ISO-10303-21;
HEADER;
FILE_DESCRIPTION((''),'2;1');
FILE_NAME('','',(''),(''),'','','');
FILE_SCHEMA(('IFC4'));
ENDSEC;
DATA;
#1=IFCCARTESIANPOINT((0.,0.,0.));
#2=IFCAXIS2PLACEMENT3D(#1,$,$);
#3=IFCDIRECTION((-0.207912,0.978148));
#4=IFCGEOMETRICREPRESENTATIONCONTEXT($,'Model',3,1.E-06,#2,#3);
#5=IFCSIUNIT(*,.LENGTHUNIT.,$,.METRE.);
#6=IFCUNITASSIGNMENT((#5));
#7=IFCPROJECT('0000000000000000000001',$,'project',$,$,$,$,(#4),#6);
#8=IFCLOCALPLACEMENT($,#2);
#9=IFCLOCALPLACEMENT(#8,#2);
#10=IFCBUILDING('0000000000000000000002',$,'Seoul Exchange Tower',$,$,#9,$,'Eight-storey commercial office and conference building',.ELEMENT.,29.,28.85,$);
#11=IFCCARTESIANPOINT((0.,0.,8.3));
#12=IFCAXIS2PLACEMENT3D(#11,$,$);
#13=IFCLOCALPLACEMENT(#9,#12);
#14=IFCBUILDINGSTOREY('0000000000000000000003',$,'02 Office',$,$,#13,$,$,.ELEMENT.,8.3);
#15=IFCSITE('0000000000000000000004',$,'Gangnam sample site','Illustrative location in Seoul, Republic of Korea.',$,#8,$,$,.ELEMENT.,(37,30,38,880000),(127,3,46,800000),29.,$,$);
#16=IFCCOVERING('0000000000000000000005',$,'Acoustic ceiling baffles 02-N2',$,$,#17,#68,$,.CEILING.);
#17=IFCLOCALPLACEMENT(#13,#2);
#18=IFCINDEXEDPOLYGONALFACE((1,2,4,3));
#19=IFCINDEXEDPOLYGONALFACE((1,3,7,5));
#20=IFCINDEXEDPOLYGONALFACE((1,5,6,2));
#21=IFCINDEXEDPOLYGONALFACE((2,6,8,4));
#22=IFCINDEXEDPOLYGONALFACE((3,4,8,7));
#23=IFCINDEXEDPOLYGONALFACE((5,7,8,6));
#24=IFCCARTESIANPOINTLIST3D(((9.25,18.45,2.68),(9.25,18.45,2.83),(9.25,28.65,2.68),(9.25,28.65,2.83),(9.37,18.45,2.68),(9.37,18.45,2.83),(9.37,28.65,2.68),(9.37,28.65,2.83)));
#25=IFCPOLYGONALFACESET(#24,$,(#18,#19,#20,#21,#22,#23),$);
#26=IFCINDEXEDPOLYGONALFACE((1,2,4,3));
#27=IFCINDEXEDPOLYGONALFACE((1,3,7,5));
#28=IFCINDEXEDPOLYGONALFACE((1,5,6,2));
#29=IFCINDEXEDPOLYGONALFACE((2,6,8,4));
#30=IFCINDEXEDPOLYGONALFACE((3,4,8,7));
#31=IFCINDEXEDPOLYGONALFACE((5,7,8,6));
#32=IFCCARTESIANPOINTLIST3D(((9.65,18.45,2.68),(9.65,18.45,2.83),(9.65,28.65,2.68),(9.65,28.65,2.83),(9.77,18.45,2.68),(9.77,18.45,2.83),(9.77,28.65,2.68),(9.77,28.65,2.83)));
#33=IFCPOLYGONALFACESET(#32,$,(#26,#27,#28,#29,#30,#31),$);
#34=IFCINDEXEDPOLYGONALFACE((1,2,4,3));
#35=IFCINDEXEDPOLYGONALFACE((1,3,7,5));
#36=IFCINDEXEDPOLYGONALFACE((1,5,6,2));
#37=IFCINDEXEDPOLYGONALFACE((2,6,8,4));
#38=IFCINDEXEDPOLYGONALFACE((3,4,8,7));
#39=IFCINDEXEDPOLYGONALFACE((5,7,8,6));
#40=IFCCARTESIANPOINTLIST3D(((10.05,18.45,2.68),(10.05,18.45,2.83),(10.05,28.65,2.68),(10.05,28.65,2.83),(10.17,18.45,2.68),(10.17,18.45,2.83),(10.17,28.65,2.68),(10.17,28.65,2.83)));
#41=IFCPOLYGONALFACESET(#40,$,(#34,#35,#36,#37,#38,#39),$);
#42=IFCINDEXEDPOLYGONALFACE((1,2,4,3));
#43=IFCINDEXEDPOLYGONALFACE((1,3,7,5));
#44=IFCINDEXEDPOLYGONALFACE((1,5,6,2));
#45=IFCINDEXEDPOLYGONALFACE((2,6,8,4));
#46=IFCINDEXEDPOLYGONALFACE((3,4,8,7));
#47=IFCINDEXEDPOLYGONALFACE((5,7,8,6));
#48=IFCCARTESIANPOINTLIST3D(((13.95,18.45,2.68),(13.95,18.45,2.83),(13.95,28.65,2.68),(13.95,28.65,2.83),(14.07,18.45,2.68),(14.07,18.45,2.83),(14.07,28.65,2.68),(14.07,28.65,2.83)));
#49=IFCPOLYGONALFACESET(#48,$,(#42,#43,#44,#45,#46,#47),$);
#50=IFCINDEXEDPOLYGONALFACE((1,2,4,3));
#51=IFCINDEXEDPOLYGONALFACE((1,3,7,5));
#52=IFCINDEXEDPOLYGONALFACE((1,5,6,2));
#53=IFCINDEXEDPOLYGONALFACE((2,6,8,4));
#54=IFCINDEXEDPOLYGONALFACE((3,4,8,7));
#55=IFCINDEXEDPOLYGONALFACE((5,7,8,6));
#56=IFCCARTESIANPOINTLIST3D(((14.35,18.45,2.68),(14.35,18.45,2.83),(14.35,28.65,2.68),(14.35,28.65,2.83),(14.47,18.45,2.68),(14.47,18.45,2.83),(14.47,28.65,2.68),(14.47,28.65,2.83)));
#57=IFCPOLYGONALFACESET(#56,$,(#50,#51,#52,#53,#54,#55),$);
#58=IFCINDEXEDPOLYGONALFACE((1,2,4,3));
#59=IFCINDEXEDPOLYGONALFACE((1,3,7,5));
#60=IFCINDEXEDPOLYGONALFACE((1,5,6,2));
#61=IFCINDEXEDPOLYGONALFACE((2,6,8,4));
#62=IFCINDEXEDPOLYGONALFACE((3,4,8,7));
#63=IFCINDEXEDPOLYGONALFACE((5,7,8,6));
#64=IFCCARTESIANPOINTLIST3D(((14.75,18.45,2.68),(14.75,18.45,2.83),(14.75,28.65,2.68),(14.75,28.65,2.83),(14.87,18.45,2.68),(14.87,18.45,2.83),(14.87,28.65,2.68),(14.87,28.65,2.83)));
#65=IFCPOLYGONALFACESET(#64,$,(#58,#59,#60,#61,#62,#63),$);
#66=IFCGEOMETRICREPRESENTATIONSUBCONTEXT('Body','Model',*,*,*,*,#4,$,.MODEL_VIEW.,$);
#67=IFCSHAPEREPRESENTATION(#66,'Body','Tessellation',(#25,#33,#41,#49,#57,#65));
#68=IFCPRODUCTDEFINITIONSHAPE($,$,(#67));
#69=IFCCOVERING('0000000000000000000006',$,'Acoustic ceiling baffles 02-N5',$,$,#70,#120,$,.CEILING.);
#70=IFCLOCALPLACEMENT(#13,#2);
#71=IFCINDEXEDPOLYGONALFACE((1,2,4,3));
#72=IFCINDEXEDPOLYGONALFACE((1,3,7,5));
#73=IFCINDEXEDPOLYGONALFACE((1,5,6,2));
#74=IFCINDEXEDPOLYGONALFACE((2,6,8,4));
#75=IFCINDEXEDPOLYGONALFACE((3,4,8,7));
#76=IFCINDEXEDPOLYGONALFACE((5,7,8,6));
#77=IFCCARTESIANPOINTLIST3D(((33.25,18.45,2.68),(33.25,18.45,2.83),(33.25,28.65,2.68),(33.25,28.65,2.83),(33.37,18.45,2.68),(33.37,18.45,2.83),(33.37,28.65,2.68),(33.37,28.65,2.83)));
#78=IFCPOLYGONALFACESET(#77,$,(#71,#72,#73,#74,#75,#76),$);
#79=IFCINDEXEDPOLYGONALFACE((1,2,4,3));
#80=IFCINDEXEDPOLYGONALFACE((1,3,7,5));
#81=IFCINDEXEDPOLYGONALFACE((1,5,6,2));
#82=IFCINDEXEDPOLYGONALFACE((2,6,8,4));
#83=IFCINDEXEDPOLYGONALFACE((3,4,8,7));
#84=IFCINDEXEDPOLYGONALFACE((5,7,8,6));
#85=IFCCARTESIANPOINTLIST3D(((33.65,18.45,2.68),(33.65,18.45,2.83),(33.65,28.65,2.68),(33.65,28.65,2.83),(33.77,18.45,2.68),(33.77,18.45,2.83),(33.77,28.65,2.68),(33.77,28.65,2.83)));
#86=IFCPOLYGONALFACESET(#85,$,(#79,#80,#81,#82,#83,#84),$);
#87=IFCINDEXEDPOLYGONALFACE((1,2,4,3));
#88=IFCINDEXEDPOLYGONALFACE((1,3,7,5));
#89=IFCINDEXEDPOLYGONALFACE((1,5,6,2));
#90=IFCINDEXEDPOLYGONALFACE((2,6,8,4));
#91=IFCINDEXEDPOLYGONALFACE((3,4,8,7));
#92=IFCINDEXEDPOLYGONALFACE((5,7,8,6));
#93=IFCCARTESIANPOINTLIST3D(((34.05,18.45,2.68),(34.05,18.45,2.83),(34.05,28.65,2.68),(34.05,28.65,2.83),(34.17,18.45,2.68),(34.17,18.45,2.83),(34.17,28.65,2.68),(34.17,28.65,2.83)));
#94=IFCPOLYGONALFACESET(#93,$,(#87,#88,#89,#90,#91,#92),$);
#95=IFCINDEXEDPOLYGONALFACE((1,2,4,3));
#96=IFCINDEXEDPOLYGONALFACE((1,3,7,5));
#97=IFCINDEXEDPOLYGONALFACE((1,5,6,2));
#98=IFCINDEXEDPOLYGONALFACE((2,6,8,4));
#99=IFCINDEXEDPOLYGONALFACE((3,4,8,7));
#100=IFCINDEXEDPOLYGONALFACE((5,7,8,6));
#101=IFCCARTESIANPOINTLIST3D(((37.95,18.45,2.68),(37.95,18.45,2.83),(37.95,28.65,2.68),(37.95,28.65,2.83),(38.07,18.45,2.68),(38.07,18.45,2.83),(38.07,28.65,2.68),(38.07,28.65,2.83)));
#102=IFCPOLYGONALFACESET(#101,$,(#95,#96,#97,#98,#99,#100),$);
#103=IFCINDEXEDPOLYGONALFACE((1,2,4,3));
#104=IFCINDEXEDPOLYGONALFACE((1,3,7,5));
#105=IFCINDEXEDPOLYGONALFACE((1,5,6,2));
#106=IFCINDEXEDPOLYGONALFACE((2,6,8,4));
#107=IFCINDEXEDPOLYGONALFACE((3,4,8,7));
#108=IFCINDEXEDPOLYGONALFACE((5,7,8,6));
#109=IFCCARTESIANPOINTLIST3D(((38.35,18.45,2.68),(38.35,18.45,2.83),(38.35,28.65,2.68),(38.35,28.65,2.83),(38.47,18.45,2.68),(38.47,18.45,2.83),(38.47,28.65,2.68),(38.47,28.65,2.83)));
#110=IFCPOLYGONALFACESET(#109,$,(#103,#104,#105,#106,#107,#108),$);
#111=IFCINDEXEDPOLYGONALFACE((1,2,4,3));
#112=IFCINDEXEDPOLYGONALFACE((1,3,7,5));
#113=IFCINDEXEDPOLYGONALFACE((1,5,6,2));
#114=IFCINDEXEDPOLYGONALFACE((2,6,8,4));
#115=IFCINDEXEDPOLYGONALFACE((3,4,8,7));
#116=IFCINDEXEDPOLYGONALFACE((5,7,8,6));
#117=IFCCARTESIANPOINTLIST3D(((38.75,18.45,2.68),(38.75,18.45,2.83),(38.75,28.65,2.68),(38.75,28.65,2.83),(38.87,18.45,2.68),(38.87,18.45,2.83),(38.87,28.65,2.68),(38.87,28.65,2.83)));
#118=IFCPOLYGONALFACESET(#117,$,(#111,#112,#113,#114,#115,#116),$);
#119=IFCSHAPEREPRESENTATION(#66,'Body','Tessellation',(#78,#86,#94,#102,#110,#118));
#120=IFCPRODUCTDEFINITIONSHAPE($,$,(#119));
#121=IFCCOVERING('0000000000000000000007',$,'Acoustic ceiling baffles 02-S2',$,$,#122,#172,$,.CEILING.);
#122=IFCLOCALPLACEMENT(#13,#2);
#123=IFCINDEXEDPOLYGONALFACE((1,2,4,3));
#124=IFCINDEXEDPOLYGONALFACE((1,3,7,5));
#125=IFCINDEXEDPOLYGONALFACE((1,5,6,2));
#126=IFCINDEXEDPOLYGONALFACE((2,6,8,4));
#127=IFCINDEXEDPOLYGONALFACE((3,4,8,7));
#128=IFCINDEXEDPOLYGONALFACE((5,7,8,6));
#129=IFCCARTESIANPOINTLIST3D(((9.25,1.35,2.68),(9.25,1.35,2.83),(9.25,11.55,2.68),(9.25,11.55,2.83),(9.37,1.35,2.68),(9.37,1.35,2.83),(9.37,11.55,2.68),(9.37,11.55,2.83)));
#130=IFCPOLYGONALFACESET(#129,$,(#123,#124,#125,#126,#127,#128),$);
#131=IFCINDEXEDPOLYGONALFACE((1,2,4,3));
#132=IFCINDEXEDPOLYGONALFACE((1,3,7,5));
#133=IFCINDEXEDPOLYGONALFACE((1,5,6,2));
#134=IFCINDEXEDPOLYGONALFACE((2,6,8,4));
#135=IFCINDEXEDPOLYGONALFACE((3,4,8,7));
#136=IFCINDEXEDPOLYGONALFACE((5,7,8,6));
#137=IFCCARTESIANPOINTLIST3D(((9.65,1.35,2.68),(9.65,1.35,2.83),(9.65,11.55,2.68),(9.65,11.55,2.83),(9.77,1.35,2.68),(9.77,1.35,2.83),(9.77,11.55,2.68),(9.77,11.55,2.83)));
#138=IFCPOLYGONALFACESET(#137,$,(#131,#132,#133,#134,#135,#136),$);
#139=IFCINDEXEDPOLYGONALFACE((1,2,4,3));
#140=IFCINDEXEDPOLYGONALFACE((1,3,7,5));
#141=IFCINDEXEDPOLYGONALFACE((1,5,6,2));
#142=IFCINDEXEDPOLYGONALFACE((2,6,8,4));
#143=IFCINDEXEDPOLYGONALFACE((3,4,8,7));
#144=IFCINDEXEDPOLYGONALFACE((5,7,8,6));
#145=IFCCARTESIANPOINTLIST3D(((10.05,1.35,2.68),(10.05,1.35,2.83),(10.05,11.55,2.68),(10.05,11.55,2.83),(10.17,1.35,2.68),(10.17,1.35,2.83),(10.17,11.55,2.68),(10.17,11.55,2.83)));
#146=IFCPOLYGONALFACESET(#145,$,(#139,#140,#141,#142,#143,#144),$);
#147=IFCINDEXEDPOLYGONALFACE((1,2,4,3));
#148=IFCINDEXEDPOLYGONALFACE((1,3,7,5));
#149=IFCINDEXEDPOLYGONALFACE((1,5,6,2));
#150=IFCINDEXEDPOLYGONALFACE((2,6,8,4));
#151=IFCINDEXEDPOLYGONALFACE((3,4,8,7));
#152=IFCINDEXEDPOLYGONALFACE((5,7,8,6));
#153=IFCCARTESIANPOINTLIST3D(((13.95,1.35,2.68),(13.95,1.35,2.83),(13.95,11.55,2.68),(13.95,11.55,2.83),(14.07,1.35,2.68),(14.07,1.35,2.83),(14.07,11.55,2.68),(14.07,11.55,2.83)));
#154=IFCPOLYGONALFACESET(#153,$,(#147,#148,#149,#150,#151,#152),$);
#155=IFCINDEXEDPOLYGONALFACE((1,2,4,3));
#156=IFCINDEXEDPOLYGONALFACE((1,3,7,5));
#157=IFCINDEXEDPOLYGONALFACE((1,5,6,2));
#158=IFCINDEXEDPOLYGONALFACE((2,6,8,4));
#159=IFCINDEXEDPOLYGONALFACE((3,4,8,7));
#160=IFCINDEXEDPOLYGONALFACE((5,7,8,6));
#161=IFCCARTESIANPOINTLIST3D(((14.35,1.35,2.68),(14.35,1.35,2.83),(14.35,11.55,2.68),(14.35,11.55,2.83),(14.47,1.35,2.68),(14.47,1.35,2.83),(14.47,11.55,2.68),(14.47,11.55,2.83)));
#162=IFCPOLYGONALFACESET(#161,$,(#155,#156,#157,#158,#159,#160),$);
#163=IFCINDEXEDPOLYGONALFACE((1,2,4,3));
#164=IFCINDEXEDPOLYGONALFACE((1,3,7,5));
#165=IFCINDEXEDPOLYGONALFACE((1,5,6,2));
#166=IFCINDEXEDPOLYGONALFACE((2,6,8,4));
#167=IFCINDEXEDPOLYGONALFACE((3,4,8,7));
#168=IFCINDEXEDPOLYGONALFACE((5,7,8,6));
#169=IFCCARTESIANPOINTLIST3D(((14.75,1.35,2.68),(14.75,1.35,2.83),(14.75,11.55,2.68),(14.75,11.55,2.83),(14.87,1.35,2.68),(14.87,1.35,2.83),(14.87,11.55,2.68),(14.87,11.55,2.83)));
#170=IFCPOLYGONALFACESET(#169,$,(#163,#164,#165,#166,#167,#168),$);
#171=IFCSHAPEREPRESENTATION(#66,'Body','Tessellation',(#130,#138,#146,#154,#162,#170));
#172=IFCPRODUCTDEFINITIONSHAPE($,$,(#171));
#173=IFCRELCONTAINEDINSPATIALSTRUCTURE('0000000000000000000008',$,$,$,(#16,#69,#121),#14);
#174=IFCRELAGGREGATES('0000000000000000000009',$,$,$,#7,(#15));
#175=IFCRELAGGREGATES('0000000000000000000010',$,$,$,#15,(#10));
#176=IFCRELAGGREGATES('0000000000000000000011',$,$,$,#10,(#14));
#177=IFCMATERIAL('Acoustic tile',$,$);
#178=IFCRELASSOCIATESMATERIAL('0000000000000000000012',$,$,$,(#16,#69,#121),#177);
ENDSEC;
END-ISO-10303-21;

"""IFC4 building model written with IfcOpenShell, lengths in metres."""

from ifc_helpers import new_model, si_unit, direction, frame, frame_2d, origin, place, context, subcontext, project, spatial, rectangle, extrude, material, element, save


model = new_model("IFC4")

# Units and contexts
model_context = context("Model", 3, precision=1e-06, world=origin(), true_north=direction((-0.207912, 0.978148)))
body_context = subcontext(model_context, "Body", "Model", "MODEL_VIEW")
ifc_project = project(units=[si_unit("LENGTHUNIT", "METRE")], contexts=[model_context])

# Site, building, storey
site_placement = place(None, origin())
site = spatial("IfcSite", under=ifc_project, at=site_placement, Name="Gangnam sample site", Description="Illustrative location in Seoul, Republic of Korea.", CompositionType="ELEMENT", RefLatitude=(37, 30, 38, 880000), RefLongitude=(127, 3, 46, 800000), RefElevation=29.0)
building_placement = place(site_placement, origin())
building = spatial("IfcBuilding", under=site, at=building_placement, Name="Seoul Exchange Tower", LongName="Eight-storey commercial office and conference building", CompositionType="ELEMENT", ElevationOfRefHeight=29.0, ElevationOfTerrain=28.85)
storey_placement = place(building_placement, frame((0.0, 0.0, 8.3)))
storey = spatial("IfcBuildingStorey", under=building, at=storey_placement, Name="02 Office", CompositionType="ELEMENT", Elevation=8.3)

# Shared definitions
placement_1 = place(storey_placement, origin())

# Coverings
ifc_material_1 = material(Name="Acoustic tile")
element("IfcCovering", 1, at=placement_1, inside=storey, material=ifc_material_1, Name="Acoustic ceiling baffles 02-N2", PredefinedType="CEILING", context=body_context, shape_type="SweptSolid", body=[
    extrude(rectangle(XDim=0.12, YDim=10.2, at=frame_2d((0.06, 5.1))), frame((9.25, 18.45, 2.68)), (0.0, 0.0, 1.0), 0.15),
    extrude(rectangle(XDim=0.12, YDim=10.2, at=frame_2d((0.06, 5.1))), frame((9.65, 18.45, 2.68)), (0.0, 0.0, 1.0), 0.15),
    extrude(rectangle(XDim=0.12, YDim=10.2, at=frame_2d((0.06, 5.1))), frame((10.05, 18.45, 2.68)), (0.0, 0.0, 1.0), 0.15),
    extrude(rectangle(XDim=0.12, YDim=10.2, at=frame_2d((0.06, 5.1))), frame((13.95, 18.45, 2.68)), (0.0, 0.0, 1.0), 0.15),
    extrude(rectangle(XDim=0.12, YDim=10.2, at=frame_2d((0.06, 5.1))), frame((14.35, 18.45, 2.68)), (0.0, 0.0, 1.0), 0.15),
    extrude(rectangle(XDim=0.12, YDim=10.2, at=frame_2d((0.06, 5.1))), frame((14.75, 18.45, 2.68)), (0.0, 0.0, 1.0), 0.15),
])
element("IfcCovering", 2, at=placement_1, inside=storey, material=ifc_material_1, Name="Acoustic ceiling baffles 02-N5", PredefinedType="CEILING", context=body_context, shape_type="SweptSolid", body=[
    extrude(rectangle(XDim=0.12, YDim=10.2, at=frame_2d((0.06, 5.1))), frame((33.25, 18.45, 2.68)), (0.0, 0.0, 1.0), 0.15),
    extrude(rectangle(XDim=0.12, YDim=10.2, at=frame_2d((0.06, 5.1))), frame((33.65, 18.45, 2.68)), (0.0, 0.0, 1.0), 0.15),
    extrude(rectangle(XDim=0.12, YDim=10.2, at=frame_2d((0.06, 5.1))), frame((34.05, 18.45, 2.68)), (0.0, 0.0, 1.0), 0.15),
    extrude(rectangle(XDim=0.12, YDim=10.2, at=frame_2d((0.06, 5.1))), frame((37.95, 18.45, 2.68)), (0.0, 0.0, 1.0), 0.15),
    extrude(rectangle(XDim=0.12, YDim=10.2, at=frame_2d((0.06, 5.1))), frame((38.35, 18.45, 2.68)), (0.0, 0.0, 1.0), 0.15),
    extrude(rectangle(XDim=0.12, YDim=10.2, at=frame_2d((0.06, 5.1))), frame((38.75, 18.45, 2.68)), (0.0, 0.0, 1.0), 0.15),
])
element("IfcCovering", 3, at=placement_1, inside=storey, material=ifc_material_1, Name="Acoustic ceiling baffles 02-S2", PredefinedType="CEILING", context=body_context, shape_type="SweptSolid", body=[
    extrude(rectangle(XDim=0.12, YDim=10.2, at=frame_2d((0.06, 5.1))), frame((9.25, 1.35, 2.68)), (0.0, 0.0, 1.0), 0.15),
    extrude(rectangle(XDim=0.12, YDim=10.2, at=frame_2d((0.06, 5.1))), frame((9.65, 1.35, 2.68)), (0.0, 0.0, 1.0), 0.15),
    extrude(rectangle(XDim=0.12, YDim=10.2, at=frame_2d((0.06, 5.1))), frame((10.05, 1.35, 2.68)), (0.0, 0.0, 1.0), 0.15),
    extrude(rectangle(XDim=0.12, YDim=10.2, at=frame_2d((0.06, 5.1))), frame((13.95, 1.35, 2.68)), (0.0, 0.0, 1.0), 0.15),
    extrude(rectangle(XDim=0.12, YDim=10.2, at=frame_2d((0.06, 5.1))), frame((14.35, 1.35, 2.68)), (0.0, 0.0, 1.0), 0.15),
    extrude(rectangle(XDim=0.12, YDim=10.2, at=frame_2d((0.06, 5.1))), frame((14.75, 1.35, 2.68)), (0.0, 0.0, 1.0), 0.15),
])

save(model, "model.ifc")
